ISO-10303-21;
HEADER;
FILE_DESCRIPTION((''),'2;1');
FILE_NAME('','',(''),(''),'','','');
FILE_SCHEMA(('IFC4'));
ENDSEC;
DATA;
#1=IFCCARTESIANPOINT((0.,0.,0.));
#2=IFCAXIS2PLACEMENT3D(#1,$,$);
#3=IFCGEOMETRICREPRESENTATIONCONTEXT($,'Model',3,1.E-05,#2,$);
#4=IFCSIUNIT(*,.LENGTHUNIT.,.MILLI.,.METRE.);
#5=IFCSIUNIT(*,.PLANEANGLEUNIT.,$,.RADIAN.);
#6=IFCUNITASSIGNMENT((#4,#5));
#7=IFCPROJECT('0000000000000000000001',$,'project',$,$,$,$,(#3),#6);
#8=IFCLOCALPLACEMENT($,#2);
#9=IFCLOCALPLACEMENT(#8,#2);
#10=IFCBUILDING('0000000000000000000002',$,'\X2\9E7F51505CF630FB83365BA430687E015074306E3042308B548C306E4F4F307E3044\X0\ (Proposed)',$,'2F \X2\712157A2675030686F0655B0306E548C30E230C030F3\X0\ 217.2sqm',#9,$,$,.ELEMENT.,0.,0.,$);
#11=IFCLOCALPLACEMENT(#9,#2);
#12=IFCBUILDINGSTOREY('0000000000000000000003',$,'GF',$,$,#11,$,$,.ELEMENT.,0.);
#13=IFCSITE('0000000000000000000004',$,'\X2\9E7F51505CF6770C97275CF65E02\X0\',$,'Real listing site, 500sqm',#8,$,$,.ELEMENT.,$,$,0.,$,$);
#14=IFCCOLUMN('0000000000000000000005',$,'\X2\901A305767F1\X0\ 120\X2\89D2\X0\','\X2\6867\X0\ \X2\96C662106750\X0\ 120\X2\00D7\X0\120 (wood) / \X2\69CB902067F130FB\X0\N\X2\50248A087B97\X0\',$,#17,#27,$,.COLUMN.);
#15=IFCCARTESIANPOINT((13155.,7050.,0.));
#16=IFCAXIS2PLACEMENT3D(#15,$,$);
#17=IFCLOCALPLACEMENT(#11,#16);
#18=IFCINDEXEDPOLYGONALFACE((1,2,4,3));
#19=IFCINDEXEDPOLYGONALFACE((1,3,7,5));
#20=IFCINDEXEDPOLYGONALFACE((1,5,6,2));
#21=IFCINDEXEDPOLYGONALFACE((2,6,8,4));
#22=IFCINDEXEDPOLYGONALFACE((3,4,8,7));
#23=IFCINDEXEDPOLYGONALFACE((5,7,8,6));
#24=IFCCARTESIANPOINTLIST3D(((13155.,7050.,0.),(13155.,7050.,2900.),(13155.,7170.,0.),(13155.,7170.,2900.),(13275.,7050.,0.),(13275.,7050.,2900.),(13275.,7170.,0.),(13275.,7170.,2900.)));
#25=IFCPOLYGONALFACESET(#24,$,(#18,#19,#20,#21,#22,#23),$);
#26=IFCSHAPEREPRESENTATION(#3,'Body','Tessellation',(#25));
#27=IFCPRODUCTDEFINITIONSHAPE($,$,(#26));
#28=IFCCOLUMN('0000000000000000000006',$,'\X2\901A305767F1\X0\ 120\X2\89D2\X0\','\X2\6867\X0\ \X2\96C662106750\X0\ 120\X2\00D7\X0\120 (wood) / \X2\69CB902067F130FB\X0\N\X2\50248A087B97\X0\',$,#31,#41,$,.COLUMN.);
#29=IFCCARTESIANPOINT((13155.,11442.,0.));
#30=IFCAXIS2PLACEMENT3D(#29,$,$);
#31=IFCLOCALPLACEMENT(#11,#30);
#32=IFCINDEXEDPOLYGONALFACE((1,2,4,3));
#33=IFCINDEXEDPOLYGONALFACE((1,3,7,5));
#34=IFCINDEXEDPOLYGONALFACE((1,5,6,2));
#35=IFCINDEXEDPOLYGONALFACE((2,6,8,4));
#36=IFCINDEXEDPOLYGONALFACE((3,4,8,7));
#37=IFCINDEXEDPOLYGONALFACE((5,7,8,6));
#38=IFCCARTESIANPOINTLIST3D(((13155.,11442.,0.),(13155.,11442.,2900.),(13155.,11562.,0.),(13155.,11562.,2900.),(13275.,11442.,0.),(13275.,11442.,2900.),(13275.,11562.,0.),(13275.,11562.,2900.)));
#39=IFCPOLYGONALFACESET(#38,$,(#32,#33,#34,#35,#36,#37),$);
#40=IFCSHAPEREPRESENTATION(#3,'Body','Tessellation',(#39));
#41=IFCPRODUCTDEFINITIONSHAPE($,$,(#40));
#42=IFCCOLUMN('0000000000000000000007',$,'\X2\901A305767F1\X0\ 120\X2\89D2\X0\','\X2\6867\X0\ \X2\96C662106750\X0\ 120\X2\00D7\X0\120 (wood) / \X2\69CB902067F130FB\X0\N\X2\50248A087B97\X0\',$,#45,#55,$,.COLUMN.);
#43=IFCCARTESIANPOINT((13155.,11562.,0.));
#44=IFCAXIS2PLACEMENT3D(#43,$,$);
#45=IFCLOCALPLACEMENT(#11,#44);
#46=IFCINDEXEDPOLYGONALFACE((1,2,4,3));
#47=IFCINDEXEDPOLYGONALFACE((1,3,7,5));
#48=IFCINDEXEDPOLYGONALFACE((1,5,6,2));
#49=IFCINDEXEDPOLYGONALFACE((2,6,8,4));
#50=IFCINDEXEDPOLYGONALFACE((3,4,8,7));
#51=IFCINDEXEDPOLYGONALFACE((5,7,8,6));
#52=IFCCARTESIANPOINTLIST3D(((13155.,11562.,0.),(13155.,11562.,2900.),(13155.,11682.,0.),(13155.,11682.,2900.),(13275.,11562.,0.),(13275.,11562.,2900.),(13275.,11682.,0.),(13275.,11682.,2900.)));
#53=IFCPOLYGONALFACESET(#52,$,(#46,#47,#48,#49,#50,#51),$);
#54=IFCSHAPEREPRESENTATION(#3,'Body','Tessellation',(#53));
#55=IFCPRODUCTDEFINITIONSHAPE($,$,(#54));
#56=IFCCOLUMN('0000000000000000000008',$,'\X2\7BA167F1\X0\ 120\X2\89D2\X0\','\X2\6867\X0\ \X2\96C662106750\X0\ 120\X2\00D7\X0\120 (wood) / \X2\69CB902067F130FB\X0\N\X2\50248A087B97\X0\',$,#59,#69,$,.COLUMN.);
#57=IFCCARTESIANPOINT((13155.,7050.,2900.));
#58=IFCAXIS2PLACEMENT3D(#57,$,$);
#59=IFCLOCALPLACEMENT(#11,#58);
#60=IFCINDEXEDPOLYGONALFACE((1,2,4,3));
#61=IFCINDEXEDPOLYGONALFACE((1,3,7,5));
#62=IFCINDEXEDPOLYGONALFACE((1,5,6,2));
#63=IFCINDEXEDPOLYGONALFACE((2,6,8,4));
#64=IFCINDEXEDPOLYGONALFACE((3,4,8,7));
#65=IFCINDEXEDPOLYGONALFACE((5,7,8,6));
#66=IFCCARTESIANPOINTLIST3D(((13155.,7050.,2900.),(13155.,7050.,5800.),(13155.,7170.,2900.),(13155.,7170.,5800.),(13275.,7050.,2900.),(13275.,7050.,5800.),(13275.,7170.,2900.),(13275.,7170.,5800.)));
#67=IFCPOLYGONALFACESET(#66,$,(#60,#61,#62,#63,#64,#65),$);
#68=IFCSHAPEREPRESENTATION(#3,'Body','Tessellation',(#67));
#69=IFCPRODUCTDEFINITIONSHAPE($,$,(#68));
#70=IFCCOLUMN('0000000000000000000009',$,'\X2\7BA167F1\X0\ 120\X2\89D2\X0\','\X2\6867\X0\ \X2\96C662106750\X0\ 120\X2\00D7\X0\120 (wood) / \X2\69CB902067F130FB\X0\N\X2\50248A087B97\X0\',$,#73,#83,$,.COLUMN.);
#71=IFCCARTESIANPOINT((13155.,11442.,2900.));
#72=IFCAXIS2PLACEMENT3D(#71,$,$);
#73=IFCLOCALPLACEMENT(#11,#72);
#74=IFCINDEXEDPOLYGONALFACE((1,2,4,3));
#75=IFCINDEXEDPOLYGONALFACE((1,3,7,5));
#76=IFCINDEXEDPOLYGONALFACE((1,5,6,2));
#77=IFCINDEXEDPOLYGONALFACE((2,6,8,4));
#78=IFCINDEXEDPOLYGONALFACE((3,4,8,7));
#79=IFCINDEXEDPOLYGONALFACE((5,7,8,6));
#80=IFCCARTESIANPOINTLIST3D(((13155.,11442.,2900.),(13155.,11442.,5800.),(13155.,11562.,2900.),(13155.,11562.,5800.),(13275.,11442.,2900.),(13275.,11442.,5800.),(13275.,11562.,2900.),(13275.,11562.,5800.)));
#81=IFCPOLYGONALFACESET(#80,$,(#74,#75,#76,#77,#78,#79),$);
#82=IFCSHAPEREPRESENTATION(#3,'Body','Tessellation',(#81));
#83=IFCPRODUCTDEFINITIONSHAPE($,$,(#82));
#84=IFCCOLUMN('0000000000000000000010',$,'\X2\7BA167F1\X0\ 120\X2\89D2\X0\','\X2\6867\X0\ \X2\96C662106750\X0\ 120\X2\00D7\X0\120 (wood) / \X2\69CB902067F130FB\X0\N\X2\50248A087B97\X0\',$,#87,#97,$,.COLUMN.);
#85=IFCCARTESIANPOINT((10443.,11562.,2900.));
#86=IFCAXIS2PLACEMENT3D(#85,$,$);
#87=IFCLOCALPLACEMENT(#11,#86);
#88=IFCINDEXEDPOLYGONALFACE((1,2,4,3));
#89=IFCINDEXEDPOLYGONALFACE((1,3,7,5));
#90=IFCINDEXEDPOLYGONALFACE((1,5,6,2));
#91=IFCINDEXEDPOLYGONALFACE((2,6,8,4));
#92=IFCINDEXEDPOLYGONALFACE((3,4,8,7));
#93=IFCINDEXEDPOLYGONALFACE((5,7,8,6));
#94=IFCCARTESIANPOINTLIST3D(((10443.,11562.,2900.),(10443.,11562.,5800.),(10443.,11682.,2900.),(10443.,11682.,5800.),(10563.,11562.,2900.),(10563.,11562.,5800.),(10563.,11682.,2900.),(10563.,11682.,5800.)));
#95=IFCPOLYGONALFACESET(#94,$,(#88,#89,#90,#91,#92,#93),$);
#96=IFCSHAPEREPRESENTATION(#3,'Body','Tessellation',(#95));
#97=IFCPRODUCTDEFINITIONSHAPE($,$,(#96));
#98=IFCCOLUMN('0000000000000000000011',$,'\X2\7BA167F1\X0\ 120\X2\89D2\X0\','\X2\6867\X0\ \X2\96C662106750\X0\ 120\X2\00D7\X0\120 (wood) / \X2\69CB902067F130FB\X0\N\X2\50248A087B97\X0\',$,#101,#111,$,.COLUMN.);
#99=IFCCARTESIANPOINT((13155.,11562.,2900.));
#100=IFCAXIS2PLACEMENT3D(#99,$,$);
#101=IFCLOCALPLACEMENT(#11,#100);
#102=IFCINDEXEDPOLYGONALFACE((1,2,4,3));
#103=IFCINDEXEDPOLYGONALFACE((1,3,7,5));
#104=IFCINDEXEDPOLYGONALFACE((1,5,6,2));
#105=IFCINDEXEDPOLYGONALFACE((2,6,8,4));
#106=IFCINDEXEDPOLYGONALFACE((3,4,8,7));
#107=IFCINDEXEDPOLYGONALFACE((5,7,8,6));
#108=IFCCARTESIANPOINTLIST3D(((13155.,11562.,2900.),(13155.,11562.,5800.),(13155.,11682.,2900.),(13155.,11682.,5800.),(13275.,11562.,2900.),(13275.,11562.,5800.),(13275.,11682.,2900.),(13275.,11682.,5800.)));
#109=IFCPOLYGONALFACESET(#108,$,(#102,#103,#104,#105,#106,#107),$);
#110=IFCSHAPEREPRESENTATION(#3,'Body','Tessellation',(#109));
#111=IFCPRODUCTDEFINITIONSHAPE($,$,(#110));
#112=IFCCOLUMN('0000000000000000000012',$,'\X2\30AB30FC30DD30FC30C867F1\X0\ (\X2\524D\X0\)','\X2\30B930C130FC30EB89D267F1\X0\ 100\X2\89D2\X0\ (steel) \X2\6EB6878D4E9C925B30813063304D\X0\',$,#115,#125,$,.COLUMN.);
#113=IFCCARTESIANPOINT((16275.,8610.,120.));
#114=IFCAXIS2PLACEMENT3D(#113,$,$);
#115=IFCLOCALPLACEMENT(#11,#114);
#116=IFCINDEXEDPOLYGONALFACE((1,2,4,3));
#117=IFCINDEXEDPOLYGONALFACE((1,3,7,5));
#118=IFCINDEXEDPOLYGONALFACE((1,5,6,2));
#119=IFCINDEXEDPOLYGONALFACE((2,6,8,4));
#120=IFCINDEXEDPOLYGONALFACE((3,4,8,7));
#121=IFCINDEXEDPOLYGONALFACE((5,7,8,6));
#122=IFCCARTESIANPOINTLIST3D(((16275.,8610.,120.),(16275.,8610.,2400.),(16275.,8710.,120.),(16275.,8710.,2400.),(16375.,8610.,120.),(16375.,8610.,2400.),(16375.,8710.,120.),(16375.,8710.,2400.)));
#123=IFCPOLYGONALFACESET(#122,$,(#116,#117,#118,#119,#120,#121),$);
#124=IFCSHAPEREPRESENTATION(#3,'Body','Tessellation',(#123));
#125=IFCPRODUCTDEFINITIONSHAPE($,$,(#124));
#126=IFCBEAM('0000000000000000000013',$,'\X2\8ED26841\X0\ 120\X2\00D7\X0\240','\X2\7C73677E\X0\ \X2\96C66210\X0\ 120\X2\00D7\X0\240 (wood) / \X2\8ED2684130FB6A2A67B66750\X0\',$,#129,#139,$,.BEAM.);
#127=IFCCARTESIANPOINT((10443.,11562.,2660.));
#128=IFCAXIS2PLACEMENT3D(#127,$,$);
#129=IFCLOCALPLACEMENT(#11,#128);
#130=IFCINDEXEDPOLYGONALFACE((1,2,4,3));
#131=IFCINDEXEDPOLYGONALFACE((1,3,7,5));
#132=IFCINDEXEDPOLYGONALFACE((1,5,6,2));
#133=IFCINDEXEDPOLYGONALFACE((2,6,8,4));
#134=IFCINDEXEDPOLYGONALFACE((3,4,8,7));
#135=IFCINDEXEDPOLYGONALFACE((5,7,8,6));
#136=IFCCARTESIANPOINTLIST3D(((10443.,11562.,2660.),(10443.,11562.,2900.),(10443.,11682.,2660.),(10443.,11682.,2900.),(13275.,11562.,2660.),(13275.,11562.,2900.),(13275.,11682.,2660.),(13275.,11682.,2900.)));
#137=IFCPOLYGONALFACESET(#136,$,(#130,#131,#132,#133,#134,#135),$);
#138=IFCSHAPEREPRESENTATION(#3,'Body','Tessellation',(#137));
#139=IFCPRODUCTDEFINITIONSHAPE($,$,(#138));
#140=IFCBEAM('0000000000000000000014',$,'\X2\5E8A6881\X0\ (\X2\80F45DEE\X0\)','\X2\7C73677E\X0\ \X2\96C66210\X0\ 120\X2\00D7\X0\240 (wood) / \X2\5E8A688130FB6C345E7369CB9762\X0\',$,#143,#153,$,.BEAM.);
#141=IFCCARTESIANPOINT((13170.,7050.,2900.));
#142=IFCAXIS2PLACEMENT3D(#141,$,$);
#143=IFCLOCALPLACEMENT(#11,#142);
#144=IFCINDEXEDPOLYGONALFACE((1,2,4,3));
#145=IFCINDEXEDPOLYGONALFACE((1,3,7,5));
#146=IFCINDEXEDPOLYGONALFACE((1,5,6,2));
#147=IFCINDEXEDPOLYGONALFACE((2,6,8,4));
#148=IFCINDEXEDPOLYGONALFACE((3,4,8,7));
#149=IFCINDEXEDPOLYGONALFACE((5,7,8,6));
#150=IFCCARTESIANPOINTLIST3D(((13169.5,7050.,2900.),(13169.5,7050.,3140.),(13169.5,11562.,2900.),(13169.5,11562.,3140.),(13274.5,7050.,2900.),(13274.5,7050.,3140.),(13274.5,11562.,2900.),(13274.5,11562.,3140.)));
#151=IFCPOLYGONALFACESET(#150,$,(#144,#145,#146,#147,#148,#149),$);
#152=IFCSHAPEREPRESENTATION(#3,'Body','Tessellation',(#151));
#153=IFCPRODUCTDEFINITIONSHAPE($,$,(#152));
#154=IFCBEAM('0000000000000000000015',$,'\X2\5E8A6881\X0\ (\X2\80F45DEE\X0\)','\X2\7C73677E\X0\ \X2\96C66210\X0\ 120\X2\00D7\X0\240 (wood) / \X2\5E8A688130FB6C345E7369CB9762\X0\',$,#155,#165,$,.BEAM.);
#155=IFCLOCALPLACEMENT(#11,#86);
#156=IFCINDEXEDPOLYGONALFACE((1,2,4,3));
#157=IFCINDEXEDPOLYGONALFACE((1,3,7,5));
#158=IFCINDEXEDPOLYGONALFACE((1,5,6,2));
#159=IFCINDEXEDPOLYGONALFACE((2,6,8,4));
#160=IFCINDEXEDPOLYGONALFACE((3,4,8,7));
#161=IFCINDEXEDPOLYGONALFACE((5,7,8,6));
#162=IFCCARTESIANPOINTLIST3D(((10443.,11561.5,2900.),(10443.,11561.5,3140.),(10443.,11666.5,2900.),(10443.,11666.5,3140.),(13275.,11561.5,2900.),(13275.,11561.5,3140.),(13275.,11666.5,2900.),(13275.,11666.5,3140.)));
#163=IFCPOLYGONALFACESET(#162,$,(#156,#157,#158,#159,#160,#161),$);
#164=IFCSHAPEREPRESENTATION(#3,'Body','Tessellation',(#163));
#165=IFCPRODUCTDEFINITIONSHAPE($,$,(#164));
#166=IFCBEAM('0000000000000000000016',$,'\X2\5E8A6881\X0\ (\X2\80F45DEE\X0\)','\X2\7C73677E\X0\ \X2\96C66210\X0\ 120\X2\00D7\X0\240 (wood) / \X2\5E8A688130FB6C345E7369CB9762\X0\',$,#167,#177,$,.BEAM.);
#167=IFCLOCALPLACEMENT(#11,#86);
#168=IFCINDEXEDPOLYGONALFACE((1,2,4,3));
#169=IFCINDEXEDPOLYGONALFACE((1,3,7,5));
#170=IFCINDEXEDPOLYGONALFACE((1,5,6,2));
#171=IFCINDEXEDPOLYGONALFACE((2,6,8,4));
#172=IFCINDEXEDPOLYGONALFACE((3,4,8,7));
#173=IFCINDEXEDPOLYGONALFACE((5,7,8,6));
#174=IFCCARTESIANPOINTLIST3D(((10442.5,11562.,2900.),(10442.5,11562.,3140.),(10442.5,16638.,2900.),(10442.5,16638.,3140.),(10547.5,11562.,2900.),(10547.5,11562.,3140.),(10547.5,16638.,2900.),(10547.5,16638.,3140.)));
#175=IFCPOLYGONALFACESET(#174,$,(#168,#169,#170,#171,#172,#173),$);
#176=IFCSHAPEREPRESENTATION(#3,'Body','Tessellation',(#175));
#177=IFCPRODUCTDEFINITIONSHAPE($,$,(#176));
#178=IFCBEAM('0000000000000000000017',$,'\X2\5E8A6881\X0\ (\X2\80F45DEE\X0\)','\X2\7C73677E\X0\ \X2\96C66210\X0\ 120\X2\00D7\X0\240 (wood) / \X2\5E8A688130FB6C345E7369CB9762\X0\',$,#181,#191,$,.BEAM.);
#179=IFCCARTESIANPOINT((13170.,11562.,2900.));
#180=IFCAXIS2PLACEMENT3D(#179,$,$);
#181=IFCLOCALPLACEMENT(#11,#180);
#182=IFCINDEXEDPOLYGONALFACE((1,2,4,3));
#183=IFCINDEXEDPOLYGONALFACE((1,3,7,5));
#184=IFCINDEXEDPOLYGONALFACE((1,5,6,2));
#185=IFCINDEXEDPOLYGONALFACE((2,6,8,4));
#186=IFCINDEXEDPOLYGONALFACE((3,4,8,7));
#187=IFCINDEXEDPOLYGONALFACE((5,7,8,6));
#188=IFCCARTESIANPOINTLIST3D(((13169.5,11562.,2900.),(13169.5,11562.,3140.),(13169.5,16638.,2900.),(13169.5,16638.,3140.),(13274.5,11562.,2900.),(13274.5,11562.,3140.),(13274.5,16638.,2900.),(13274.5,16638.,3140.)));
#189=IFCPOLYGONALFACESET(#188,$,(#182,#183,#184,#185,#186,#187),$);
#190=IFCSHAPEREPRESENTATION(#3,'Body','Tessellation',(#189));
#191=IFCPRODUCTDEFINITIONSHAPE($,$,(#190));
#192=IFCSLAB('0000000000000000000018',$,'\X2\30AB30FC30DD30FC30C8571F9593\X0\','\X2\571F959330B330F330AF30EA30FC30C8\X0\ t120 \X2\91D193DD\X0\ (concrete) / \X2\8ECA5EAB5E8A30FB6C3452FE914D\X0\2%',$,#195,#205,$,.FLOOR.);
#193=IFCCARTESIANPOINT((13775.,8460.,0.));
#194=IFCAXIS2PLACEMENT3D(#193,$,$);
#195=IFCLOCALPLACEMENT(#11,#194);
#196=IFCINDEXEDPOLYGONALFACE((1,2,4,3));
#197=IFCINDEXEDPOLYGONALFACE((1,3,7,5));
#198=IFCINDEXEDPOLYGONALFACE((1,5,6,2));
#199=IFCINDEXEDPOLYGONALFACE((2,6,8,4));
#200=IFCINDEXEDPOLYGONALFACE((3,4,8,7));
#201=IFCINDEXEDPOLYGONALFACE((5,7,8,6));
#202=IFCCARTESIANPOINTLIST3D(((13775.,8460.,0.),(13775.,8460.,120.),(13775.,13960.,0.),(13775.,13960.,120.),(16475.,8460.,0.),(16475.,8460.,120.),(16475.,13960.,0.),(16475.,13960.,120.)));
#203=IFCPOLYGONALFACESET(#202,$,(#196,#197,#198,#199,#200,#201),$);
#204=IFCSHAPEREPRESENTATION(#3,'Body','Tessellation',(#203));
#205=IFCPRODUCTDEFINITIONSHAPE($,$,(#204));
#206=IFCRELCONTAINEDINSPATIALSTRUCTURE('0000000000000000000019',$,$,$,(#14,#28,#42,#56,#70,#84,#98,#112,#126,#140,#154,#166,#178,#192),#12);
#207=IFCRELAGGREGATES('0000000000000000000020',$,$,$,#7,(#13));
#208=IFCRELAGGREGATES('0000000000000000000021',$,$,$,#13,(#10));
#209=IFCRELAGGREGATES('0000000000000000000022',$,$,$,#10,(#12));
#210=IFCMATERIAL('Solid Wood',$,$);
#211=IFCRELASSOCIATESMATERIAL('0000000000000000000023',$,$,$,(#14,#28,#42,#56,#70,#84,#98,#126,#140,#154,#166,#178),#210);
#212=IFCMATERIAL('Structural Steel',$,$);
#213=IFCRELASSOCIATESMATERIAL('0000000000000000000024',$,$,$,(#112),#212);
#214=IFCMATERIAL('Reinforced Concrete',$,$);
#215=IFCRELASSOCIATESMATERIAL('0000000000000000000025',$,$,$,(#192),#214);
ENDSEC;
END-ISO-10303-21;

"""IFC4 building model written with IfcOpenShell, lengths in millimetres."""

from ifc_helpers import new_model, si_unit, frame, frame_2d, origin, place, context, project, spatial, rectangle, extrude, material, element, save


model = new_model("IFC4")

# Units and contexts
model_context = context("Model", 3, precision=1e-05, world=origin())
ifc_project = project(units=[si_unit("LENGTHUNIT", "METRE", prefix="MILLI"), si_unit("PLANEANGLEUNIT", "RADIAN")], contexts=[model_context])

# Site, building, storey
site_placement = place(None, origin())
site = spatial("IfcSite", under=ifc_project, at=site_placement, Name="鹿児島県霧島市", ObjectType="Real listing site, 500sqm", CompositionType="ELEMENT", RefElevation=0.0)
building_placement = place(site_placement, origin())
building = spatial("IfcBuilding", under=site, at=building_placement, Name="鹿児島・茶室と縁側のある和の住まい (Proposed)", ObjectType="2F 無垢材と漆喰の和モダン 217.2sqm", CompositionType="ELEMENT", ElevationOfRefHeight=0.0, ElevationOfTerrain=0.0)
storey_placement = place(building_placement, origin())
storey = spatial("IfcBuildingStorey", under=building, at=storey_placement, Name="GF", CompositionType="ELEMENT", Elevation=0.0)

# Columns
ifc_material_1 = material(Name="Solid Wood")
column_1_placement = place(storey_placement, frame((13155.0, 7050.0, 0.0)))
element("IfcColumn", 1, at=column_1_placement, inside=storey, material=ifc_material_1, Name="通し柱 120角", Description="桧 集成材 120×120 (wood) / 構造柱・N値計算", PredefinedType="COLUMN", context=model_context, shape_type="SweptSolid", body=[
    extrude(rectangle(XDim=120.0, YDim=120.0, at=frame_2d((60.0, 60.0))), frame((13155.0, 7050.0, 0.0)), (0.0, 0.0, 1.0), 2900.0),
])
column_2_placement = place(storey_placement, frame((13155.0, 11442.0, 0.0)))
element("IfcColumn", 2, at=column_2_placement, inside=storey, material=ifc_material_1, Name="通し柱 120角", Description="桧 集成材 120×120 (wood) / 構造柱・N値計算", PredefinedType="COLUMN", context=model_context, shape_type="SweptSolid", body=[
    extrude(rectangle(XDim=120.0, YDim=120.0, at=frame_2d((60.0, 60.0))), frame((13155.0, 11442.0, 0.0)), (0.0, 0.0, 1.0), 2900.0),
])
column_3_placement = place(storey_placement, frame((13155.0, 11562.0, 0.0)))
element("IfcColumn", 3, at=column_3_placement, inside=storey, material=ifc_material_1, Name="通し柱 120角", Description="桧 集成材 120×120 (wood) / 構造柱・N値計算", PredefinedType="COLUMN", context=model_context, shape_type="SweptSolid", body=[
    extrude(rectangle(XDim=120.0, YDim=120.0, at=frame_2d((60.0, 60.0))), frame((13155.0, 11562.0, 0.0)), (0.0, 0.0, 1.0), 2900.0),
])
column_4_placement = place(storey_placement, frame((13155.0, 7050.0, 2900.0)))
element("IfcColumn", 4, at=column_4_placement, inside=storey, material=ifc_material_1, Name="管柱 120角", Description="桧 集成材 120×120 (wood) / 構造柱・N値計算", PredefinedType="COLUMN", context=model_context, shape_type="SweptSolid", body=[
    extrude(rectangle(XDim=120.0, YDim=120.0, at=frame_2d((60.0, 60.0))), frame((13155.0, 7050.0, 2900.0)), (0.0, 0.0, 1.0), 2900.0),
])
column_5_placement = place(storey_placement, frame((13155.0, 11442.0, 2900.0)))
element("IfcColumn", 5, at=column_5_placement, inside=storey, material=ifc_material_1, Name="管柱 120角", Description="桧 集成材 120×120 (wood) / 構造柱・N値計算", PredefinedType="COLUMN", context=model_context, shape_type="SweptSolid", body=[
    extrude(rectangle(XDim=120.0, YDim=120.0, at=frame_2d((60.0, 60.0))), frame((13155.0, 11442.0, 2900.0)), (0.0, 0.0, 1.0), 2900.0),
])
column_6_placement = place(storey_placement, frame((10443.0, 11562.0, 2900.0)))
element("IfcColumn", 6, at=column_6_placement, inside=storey, material=ifc_material_1, Name="管柱 120角", Description="桧 集成材 120×120 (wood) / 構造柱・N値計算", PredefinedType="COLUMN", context=model_context, shape_type="SweptSolid", body=[
    extrude(rectangle(XDim=120.0, YDim=120.0, at=frame_2d((60.0, 60.0))), frame((10443.0, 11562.0, 2900.0)), (0.0, 0.0, 1.0), 2900.0),
])
column_7_placement = place(storey_placement, frame((13155.0, 11562.0, 2900.0)))
element("IfcColumn", 7, at=column_7_placement, inside=storey, material=ifc_material_1, Name="管柱 120角", Description="桧 集成材 120×120 (wood) / 構造柱・N値計算", PredefinedType="COLUMN", context=model_context, shape_type="SweptSolid", body=[
    extrude(rectangle(XDim=120.0, YDim=120.0, at=frame_2d((60.0, 60.0))), frame((13155.0, 11562.0, 2900.0)), (0.0, 0.0, 1.0), 2900.0),
])
ifc_material_2 = material(Name="Structural Steel")
column_8_placement = place(storey_placement, frame((16275.0, 8610.0, 120.0)))
element("IfcColumn", 8, at=column_8_placement, inside=storey, material=ifc_material_2, Name="カーポート柱 (前)", Description="スチール角柱 100角 (steel) 溶融亜鉛めっき", PredefinedType="COLUMN", context=model_context, shape_type="SweptSolid", body=[
    extrude(rectangle(XDim=100.0, YDim=100.0, at=frame_2d((50.0, 50.0))), frame((16275.0, 8610.0, 120.0)), (0.0, 0.0, 1.0), 2280.0),
])

# Beams
beam_1_placement = place(storey_placement, frame((10443.0, 11562.0, 2660.0)))
element("IfcBeam", 9, at=beam_1_placement, inside=storey, material=ifc_material_1, Name="軒桁 120×240", Description="米松 集成 120×240 (wood) / 軒桁・横架材", PredefinedType="BEAM", context=model_context, shape_type="SweptSolid", body=[
    extrude(rectangle(XDim=2832.0, YDim=120.0, at=frame_2d((1416.0, 60.0))), frame((10443.0, 11562.0, 2660.0)), (0.0, 0.0, 1.0), 240.0),
])
beam_2_placement = place(storey_placement, frame((13170.0, 7050.0, 2900.0)))
element("IfcBeam", 10, at=beam_2_placement, inside=storey, material=ifc_material_1, Name="床梁 (胴差)", Description="米松 集成 120×240 (wood) / 床梁・水平構面", PredefinedType="BEAM", context=model_context, shape_type="SweptSolid", body=[
    extrude(rectangle(XDim=105.0, YDim=4512.0, at=frame_2d((52.0, 2256.0))), frame((13170.0, 7050.0, 2900.0)), (0.0, 0.0, 1.0), 240.0),
])
beam_3_placement = place(storey_placement, frame((10443.0, 11562.0, 2900.0)))
element("IfcBeam", 11, at=beam_3_placement, inside=storey, material=ifc_material_1, Name="床梁 (胴差)", Description="米松 集成 120×240 (wood) / 床梁・水平構面", PredefinedType="BEAM", context=model_context, shape_type="SweptSolid", body=[
    extrude(rectangle(XDim=2832.0, YDim=105.0, at=frame_2d((1416.0, 52.0))), frame((10443.0, 11562.0, 2900.0)), (0.0, 0.0, 1.0), 240.0),
])
beam_4_placement = place(storey_placement, frame((10443.0, 11562.0, 2900.0)))
element("IfcBeam", 12, at=beam_4_placement, inside=storey, material=ifc_material_1, Name="床梁 (胴差)", Description="米松 集成 120×240 (wood) / 床梁・水平構面", PredefinedType="BEAM", context=model_context, shape_type="SweptSolid", body=[
    extrude(rectangle(XDim=105.0, YDim=5076.0, at=frame_2d((52.0, 2538.0))), frame((10443.0, 11562.0, 2900.0)), (0.0, 0.0, 1.0), 240.0),
])
beam_5_placement = place(storey_placement, frame((13170.0, 11562.0, 2900.0)))
element("IfcBeam", 13, at=beam_5_placement, inside=storey, material=ifc_material_1, Name="床梁 (胴差)", Description="米松 集成 120×240 (wood) / 床梁・水平構面", PredefinedType="BEAM", context=model_context, shape_type="SweptSolid", body=[
    extrude(rectangle(XDim=105.0, YDim=5076.0, at=frame_2d((52.0, 2538.0))), frame((13170.0, 11562.0, 2900.0)), (0.0, 0.0, 1.0), 240.0),
])

# Slab
ifc_material_3 = material(Name="Reinforced Concrete")
slab_placement = place(storey_placement, frame((13775.0, 8460.0, 0.0)))
element("IfcSlab", 14, at=slab_placement, inside=storey, material=ifc_material_3, Name="カーポート土間", Description="土間コンクリート t120 金鏝 (concrete) / 車庫床・水勾配2%", PredefinedType="FLOOR", context=model_context, shape_type="SweptSolid", body=[
    extrude(rectangle(XDim=2700.0, YDim=5500.0, at=frame_2d((1350.0, 2750.0))), frame((13775.0, 8460.0, 0.0)), (0.0, 0.0, 1.0), 120.0),
])

save(model, "model.ifc")
